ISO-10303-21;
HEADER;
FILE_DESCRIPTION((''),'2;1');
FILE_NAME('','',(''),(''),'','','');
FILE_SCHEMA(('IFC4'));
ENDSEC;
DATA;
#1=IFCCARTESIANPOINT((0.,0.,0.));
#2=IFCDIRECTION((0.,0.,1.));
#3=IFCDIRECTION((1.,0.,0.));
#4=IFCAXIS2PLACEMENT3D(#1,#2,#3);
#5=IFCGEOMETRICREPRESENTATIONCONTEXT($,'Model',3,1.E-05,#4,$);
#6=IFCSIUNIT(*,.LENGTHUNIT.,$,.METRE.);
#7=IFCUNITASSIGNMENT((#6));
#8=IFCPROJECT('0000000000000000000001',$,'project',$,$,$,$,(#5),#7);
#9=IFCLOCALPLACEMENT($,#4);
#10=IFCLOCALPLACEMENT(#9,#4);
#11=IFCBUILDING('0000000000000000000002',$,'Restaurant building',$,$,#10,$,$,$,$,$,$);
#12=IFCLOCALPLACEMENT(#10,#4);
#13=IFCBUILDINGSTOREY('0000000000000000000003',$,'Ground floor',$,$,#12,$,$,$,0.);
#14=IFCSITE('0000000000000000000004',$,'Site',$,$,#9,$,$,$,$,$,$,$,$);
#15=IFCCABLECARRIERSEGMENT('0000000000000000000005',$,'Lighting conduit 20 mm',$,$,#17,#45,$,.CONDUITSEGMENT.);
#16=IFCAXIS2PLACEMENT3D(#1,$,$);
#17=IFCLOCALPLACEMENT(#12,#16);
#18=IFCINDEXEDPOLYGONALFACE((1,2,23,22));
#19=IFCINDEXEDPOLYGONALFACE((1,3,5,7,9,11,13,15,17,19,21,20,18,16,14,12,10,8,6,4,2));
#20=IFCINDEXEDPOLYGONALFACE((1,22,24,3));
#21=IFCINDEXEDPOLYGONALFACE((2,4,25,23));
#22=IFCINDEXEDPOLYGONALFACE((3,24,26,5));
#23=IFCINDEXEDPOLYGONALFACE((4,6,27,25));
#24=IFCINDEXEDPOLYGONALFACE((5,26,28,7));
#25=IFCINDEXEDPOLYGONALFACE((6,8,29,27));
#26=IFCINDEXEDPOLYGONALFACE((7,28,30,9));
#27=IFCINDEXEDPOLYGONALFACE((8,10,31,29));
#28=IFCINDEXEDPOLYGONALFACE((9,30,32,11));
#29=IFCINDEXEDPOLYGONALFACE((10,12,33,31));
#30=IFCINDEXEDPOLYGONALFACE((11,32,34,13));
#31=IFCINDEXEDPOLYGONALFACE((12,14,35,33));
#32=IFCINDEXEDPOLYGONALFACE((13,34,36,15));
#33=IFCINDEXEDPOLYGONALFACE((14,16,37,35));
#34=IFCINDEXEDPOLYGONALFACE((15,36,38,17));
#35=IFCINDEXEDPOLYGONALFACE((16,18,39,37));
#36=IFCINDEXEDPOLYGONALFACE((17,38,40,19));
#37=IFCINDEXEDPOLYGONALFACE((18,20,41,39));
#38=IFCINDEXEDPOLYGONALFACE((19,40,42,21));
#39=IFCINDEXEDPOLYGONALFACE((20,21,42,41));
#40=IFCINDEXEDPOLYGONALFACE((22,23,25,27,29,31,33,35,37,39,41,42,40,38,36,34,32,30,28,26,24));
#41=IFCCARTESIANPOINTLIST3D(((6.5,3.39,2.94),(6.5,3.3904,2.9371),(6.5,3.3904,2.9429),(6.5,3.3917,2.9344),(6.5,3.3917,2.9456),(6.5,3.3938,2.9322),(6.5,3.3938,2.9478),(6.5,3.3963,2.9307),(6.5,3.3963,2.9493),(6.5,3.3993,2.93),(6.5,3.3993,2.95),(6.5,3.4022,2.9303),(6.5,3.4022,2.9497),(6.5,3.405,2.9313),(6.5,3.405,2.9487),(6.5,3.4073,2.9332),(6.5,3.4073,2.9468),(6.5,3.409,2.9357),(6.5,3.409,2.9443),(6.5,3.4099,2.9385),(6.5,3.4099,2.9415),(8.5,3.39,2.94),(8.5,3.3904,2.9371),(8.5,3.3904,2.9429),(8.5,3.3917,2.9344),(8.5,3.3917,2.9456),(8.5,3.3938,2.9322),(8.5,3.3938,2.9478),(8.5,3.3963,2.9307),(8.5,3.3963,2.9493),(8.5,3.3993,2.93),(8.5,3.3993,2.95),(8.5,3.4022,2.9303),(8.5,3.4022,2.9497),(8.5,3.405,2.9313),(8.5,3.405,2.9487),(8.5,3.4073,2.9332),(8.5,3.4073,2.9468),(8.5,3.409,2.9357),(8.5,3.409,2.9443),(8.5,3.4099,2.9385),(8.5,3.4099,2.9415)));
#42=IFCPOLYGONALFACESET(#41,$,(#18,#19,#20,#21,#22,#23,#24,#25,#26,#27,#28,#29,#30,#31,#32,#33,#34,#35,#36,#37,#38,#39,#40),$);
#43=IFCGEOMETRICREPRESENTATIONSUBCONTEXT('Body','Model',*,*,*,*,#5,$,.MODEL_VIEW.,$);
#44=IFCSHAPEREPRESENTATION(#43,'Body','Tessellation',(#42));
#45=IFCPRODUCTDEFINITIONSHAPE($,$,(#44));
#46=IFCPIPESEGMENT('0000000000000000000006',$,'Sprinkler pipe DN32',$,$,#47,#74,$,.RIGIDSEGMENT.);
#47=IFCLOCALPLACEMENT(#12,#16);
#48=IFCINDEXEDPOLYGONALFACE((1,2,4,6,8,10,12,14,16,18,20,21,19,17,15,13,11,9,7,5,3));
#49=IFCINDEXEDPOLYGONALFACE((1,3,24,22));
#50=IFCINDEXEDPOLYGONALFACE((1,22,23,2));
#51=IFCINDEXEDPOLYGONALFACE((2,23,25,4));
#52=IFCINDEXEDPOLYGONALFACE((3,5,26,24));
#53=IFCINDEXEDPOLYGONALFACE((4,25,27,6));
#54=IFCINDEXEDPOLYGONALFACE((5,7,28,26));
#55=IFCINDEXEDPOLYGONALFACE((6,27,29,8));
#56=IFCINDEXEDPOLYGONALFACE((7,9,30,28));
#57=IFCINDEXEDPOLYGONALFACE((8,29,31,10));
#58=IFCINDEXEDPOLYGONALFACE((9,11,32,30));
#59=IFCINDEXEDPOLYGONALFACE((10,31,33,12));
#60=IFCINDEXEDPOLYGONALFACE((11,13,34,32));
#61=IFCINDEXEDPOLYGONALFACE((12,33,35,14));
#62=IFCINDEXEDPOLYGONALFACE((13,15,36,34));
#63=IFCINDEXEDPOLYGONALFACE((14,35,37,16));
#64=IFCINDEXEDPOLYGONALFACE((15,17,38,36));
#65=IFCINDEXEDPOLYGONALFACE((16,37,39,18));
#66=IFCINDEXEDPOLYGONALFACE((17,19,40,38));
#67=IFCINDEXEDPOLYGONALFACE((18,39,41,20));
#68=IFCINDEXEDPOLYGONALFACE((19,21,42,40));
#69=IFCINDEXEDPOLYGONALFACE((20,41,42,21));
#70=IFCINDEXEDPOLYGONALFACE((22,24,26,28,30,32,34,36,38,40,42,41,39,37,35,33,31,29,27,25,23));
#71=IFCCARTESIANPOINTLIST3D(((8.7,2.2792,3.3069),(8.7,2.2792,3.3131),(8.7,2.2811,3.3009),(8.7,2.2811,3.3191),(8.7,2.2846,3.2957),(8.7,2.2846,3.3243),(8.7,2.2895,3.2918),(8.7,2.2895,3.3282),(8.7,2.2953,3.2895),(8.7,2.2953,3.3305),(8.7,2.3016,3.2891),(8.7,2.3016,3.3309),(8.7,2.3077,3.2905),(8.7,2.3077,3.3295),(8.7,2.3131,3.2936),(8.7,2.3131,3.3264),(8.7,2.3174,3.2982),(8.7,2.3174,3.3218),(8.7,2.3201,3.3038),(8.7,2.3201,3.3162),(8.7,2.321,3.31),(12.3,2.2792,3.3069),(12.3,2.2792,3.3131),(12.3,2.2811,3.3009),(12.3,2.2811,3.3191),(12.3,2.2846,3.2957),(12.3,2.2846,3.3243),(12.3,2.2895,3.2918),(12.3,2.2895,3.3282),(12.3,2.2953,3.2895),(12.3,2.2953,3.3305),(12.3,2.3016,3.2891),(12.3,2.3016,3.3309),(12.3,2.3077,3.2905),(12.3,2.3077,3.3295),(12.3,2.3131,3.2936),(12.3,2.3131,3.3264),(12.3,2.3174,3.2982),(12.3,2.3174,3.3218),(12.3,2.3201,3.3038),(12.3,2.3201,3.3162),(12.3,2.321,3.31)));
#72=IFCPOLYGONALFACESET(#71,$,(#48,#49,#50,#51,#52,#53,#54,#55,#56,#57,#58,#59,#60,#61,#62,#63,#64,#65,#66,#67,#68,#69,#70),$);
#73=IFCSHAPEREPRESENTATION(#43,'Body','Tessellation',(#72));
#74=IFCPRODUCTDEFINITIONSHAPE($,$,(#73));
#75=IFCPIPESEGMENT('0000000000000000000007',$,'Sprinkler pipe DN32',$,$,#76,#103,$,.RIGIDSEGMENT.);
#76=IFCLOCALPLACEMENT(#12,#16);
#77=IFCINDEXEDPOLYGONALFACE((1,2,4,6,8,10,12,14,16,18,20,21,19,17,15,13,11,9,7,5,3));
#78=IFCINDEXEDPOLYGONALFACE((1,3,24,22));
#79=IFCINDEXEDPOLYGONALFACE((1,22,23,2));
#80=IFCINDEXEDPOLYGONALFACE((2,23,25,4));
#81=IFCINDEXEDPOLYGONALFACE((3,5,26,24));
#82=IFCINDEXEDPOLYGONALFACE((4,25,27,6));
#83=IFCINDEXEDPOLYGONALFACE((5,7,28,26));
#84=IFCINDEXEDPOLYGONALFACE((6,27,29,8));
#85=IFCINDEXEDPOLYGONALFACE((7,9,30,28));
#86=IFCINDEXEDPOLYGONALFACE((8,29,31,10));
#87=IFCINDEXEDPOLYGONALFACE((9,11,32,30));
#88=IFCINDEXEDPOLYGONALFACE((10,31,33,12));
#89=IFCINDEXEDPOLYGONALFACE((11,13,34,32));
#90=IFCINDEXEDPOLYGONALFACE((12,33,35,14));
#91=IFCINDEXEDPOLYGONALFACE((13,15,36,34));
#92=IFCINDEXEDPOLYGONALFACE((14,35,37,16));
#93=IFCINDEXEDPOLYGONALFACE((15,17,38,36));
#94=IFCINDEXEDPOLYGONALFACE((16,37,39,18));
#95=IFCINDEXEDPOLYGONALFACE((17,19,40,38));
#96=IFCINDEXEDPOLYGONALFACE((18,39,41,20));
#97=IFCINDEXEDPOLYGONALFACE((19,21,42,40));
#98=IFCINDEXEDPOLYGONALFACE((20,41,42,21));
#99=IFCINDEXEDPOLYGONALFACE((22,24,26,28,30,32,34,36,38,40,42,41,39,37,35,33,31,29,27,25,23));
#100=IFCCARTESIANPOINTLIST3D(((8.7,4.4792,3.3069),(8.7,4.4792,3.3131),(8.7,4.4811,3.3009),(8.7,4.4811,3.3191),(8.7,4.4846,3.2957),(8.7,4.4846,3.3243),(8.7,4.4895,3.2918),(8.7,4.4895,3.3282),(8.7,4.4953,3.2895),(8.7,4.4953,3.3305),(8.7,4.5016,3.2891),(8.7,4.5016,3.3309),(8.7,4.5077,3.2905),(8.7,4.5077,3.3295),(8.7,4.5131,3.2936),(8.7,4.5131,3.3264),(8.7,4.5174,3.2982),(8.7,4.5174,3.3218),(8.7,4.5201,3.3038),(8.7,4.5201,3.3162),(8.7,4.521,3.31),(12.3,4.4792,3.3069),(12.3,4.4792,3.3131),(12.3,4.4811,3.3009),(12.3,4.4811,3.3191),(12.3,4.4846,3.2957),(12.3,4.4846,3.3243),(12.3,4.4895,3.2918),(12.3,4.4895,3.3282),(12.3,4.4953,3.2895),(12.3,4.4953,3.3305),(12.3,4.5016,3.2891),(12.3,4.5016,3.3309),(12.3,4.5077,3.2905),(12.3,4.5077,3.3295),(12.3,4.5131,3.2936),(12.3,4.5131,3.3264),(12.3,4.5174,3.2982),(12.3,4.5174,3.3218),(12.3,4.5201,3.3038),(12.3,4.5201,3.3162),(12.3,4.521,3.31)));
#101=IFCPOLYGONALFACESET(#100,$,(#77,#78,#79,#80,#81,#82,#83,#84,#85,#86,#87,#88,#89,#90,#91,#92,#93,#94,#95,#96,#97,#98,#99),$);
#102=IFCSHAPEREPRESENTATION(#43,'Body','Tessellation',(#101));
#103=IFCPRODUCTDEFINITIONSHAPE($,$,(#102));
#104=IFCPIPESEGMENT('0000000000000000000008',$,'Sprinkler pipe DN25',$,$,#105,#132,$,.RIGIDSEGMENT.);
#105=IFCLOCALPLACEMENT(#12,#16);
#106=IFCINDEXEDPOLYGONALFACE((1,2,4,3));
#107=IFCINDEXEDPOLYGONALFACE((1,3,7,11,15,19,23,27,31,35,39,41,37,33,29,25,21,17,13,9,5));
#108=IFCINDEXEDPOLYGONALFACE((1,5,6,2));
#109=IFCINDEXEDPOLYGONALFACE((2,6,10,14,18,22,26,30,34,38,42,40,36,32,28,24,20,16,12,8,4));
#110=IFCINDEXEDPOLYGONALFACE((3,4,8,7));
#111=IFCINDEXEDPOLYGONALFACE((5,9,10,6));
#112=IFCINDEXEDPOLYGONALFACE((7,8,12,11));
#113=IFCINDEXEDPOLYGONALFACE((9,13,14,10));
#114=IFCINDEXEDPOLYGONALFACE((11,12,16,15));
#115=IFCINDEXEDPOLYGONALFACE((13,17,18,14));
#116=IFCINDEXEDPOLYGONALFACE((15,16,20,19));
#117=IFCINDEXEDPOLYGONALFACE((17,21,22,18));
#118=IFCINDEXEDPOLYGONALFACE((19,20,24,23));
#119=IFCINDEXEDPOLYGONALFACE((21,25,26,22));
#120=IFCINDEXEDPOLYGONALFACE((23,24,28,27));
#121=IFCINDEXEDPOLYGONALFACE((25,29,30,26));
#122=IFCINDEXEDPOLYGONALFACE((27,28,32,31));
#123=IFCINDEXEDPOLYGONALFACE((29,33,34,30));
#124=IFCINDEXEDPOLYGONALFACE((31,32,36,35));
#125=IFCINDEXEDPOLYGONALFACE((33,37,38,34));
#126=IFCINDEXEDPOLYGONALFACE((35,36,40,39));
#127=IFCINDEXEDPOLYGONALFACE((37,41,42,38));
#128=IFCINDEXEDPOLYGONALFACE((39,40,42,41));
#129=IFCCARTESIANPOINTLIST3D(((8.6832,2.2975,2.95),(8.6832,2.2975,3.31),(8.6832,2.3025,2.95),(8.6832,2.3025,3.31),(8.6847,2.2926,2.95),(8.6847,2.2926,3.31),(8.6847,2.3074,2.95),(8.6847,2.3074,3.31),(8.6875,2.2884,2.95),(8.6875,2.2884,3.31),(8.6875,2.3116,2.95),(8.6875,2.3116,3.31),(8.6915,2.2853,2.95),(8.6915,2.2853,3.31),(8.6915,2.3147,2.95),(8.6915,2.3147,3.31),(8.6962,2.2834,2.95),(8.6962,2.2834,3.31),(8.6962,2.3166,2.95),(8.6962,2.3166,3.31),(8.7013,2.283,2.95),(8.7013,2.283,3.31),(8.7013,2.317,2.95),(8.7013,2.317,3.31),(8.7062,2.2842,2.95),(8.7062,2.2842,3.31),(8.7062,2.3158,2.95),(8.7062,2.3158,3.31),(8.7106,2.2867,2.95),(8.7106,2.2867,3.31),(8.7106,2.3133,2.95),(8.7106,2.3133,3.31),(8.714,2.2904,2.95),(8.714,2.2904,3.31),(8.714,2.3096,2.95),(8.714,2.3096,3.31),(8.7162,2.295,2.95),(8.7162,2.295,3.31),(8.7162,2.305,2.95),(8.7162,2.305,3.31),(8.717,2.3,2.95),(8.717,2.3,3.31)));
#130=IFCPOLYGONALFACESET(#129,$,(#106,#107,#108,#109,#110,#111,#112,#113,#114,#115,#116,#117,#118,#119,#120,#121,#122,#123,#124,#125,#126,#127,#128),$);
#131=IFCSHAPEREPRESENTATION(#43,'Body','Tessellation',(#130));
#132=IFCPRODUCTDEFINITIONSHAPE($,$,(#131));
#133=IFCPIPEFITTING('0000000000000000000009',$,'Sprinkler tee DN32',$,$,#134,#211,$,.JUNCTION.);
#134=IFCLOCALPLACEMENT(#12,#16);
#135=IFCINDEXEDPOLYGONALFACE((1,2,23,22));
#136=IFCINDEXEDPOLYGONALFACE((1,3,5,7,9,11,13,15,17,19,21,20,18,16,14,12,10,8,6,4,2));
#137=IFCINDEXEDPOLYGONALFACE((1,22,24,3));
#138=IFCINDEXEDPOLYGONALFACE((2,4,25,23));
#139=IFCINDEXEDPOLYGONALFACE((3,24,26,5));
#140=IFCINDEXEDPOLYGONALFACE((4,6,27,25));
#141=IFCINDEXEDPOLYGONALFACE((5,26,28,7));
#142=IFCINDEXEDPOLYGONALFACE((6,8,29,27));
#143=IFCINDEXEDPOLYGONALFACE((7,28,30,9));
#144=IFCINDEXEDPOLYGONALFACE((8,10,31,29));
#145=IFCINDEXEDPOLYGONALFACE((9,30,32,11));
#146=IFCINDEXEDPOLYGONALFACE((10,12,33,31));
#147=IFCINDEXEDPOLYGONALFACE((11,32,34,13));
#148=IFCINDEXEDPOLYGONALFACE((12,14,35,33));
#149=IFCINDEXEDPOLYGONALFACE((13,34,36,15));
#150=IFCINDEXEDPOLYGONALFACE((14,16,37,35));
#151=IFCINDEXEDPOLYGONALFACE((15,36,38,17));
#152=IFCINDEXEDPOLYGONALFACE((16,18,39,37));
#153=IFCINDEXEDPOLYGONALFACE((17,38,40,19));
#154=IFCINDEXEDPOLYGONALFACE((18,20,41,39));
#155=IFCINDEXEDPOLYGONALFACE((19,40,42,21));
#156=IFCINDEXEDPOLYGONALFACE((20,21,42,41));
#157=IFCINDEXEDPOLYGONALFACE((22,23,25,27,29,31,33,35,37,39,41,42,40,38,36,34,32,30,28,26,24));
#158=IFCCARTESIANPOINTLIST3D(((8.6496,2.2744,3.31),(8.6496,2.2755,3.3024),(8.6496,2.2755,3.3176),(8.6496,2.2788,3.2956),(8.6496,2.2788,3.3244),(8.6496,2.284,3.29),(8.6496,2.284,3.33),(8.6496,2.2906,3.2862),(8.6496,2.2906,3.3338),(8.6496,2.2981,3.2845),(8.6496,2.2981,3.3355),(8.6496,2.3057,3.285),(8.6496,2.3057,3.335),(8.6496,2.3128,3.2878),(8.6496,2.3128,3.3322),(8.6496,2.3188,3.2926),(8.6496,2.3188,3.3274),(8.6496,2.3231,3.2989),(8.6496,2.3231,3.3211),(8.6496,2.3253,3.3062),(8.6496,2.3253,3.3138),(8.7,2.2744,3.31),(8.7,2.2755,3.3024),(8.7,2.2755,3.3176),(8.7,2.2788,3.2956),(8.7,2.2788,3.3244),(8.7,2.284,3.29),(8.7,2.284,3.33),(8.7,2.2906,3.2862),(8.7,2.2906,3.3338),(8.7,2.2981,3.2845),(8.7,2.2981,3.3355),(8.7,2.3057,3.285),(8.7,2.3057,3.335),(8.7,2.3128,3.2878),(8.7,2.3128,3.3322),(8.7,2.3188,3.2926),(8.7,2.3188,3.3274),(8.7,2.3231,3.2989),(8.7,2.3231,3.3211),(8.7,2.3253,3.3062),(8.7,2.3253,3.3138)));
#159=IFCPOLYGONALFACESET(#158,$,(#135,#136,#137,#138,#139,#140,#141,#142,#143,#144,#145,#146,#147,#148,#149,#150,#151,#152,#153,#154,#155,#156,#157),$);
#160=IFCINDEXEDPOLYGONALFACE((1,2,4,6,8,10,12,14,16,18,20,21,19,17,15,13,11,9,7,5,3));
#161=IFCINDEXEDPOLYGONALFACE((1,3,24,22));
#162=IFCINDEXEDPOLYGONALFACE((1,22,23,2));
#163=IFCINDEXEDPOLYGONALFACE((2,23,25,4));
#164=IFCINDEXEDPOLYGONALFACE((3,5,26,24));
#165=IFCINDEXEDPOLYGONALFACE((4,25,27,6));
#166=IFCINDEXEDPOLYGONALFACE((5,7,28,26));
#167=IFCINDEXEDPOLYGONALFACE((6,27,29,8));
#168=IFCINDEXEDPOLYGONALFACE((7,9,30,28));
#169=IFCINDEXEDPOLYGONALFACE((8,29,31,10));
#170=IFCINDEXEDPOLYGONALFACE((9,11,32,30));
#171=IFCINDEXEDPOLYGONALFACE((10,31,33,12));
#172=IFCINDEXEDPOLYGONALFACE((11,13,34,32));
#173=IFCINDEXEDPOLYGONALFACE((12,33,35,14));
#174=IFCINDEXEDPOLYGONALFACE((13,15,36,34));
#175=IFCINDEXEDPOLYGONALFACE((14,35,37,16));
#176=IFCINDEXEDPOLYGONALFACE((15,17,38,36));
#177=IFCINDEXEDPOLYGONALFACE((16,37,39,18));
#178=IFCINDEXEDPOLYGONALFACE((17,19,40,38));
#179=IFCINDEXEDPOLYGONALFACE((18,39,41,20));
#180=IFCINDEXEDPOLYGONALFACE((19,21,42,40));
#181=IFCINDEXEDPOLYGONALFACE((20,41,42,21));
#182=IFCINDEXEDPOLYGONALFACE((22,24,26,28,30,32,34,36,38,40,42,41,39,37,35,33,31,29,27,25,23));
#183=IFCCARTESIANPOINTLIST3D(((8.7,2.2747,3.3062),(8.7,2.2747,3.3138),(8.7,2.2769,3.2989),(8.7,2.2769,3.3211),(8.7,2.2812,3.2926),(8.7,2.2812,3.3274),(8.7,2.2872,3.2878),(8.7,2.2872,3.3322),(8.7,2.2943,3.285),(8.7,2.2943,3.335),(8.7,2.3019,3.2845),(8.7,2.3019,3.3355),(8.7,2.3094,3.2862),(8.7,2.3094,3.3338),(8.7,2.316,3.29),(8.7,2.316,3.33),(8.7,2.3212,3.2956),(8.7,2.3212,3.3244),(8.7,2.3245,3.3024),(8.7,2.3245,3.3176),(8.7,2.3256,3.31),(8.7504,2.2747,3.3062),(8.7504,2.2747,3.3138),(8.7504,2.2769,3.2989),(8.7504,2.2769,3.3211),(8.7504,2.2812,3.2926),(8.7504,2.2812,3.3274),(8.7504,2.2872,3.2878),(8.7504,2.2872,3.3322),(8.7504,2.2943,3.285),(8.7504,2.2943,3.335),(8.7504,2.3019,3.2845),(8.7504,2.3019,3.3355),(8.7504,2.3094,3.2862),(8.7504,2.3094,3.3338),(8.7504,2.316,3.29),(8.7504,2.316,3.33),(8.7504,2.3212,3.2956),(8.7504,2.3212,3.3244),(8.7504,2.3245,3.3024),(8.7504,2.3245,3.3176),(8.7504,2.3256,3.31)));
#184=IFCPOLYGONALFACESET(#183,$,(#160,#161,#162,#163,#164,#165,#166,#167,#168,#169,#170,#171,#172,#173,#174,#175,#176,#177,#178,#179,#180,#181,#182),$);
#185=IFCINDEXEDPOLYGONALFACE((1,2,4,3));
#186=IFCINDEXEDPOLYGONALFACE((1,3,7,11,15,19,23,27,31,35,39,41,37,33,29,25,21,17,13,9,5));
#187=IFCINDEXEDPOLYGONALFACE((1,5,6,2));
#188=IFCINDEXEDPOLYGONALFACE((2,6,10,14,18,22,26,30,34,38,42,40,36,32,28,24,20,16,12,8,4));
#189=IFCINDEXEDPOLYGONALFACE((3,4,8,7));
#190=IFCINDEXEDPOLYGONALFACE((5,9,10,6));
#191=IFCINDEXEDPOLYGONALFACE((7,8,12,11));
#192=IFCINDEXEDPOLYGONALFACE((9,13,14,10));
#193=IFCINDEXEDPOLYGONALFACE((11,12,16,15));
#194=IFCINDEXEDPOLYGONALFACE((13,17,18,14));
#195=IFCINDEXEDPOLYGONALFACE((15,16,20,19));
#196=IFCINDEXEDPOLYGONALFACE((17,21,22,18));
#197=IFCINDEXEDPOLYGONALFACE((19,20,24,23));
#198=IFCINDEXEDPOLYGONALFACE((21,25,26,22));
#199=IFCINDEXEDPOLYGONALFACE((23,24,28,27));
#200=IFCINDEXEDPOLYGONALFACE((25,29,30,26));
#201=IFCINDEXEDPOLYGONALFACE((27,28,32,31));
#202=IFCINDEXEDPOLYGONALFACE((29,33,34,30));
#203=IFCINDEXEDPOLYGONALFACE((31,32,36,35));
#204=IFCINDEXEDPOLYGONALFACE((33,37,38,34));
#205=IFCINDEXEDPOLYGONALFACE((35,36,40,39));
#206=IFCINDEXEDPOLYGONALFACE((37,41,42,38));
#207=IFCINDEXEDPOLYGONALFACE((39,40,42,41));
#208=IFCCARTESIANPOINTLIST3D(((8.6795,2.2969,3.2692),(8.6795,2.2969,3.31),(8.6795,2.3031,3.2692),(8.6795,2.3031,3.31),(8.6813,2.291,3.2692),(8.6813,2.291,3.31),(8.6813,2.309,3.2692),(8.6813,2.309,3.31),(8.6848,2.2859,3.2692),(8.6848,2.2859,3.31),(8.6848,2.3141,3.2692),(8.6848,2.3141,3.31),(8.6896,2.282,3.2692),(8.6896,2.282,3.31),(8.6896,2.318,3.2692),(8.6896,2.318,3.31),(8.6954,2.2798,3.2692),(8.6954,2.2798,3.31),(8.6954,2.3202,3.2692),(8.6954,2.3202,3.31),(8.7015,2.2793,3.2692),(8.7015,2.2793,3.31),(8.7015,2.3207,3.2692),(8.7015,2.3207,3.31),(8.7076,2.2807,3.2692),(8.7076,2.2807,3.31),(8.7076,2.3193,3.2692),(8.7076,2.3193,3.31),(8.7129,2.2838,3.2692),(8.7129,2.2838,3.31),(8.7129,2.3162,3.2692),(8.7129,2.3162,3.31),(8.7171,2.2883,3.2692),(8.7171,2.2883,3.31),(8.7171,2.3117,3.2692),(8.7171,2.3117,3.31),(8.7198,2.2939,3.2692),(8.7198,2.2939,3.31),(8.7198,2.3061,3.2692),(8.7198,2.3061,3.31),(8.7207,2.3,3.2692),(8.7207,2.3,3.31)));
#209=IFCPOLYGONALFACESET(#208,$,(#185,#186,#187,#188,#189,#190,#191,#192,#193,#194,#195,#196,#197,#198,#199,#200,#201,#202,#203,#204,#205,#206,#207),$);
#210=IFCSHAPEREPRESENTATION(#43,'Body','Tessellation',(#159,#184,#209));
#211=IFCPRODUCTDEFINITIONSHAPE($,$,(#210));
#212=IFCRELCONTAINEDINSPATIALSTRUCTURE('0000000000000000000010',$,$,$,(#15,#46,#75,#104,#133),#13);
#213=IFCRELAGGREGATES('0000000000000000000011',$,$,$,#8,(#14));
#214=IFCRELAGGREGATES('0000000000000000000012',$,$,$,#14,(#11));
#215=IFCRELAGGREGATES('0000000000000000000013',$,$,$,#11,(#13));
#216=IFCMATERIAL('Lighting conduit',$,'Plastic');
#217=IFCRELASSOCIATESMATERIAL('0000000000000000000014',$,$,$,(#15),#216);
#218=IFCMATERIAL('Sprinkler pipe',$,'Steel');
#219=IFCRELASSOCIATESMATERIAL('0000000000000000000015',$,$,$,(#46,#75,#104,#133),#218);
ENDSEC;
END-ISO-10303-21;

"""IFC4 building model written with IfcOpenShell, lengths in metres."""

from ifc_helpers import new_model, si_unit, frame, origin_with_axes, origin_2d, place, context, subcontext, project, spatial, circle, extrude, material, element, save


model = new_model("IFC4")

# Units and contexts
model_context = context("Model", 3, precision=1e-05, world=origin_with_axes())
body_context = subcontext(model_context, "Body", "Model", "MODEL_VIEW")
ifc_project = project(units=[si_unit("LENGTHUNIT", "METRE")], contexts=[model_context])

# Site, building, storey
site_placement = place(None, origin_with_axes())
site = spatial("IfcSite", under=ifc_project, at=site_placement, Name="Site")
building_placement = place(site_placement, origin_with_axes())
building = spatial("IfcBuilding", under=site, at=building_placement, Name="Restaurant building")
storey_placement = place(building_placement, origin_with_axes())
storey = spatial("IfcBuildingStorey", under=building, at=storey_placement, Name="Ground floor", Elevation=0.0)

# Cable carrier segment
ifc_material_1 = material(Name="Lighting conduit", Category="Plastic")
cable_carrier_segment_1_placement = place(storey_placement, frame((8.5, 3.4, 2.94)))
element("IfcCableCarrierSegment", 1, at=cable_carrier_segment_1_placement, inside=storey, material=ifc_material_1, Name="Lighting conduit 20 mm", PredefinedType="CONDUITSEGMENT", context=body_context, shape_type="SweptSolid", body=[
    extrude(circle(Radius=0.01, at=origin_2d()), frame((0.0, 0.0, 0.0), z_axis=(-1.0, 0.0, 0.0), x_axis=(0.0, -1.0, 0.0)), (0.0, 0.0, 1.0), 2.0),
])

# Pipe segments
ifc_material_2 = material(Name="Sprinkler pipe", Category="Steel")
for number, where, name in (
    (2, (8.7, 2.3, 3.31), "Sprinkler pipe DN32"),
    (3, (8.7, 4.5, 3.31), "Sprinkler pipe DN32"),
):
    element("IfcPipeSegment", number, at=place(storey_placement, frame(where)), inside=storey, material=ifc_material_2, Name=name, PredefinedType="RIGIDSEGMENT", context=body_context, shape_type="SweptSolid", body=[
        extrude(circle(Radius=0.021, at=origin_2d()), frame((0.0, 0.0, 0.0), z_axis=(1.0, 0.0, 0.0), x_axis=(0.0, 1.0, 0.0)), (0.0, 0.0, 1.0), 3.6),
    ])
pipe_segment_placement = place(storey_placement, frame((8.7, 2.3, 3.31)))
element("IfcPipeSegment", 4, at=pipe_segment_placement, inside=storey, material=ifc_material_2, Name="Sprinkler pipe DN25", PredefinedType="RIGIDSEGMENT", context=body_context, shape_type="SweptSolid", body=[
    extrude(circle(Radius=0.017, at=origin_2d()), frame((0.0, 0.0, 0.0), z_axis=(0.0, 0.0, -1.0), x_axis=(1.0, 0.0, 0.0)), (0.0, 0.0, 1.0), 0.36),
])

# Pipe fitting
pipe_fitting_placement = place(storey_placement, frame((8.7, 2.3, 3.31)))
element("IfcPipeFitting", 5, at=pipe_fitting_placement, inside=storey, material=ifc_material_2, Name="Sprinkler tee DN32", PredefinedType="JUNCTION", context=body_context, shape_type="SweptSolid", body=[
    extrude(circle(Radius=0.0256, at=origin_2d()), frame((0.0, 0.0, 0.0), z_axis=(-1.0, 0.0, 0.0), x_axis=(0.0, -1.0, 0.0)), (0.0, 0.0, 1.0), 0.0504),
    extrude(circle(Radius=0.0256, at=origin_2d()), frame((0.0, 0.0, 0.0), z_axis=(1.0, 0.0, 0.0), x_axis=(0.0, 1.0, 0.0)), (0.0, 0.0, 1.0), 0.0504),
    extrude(circle(Radius=0.0207, at=origin_2d()), frame((0.0, 0.0, 0.0), z_axis=(0.0, 0.0, -1.0), x_axis=(1.0, 0.0, 0.0)), (0.0, 0.0, 1.0), 0.0408),
])

save(model, "model.ifc")
